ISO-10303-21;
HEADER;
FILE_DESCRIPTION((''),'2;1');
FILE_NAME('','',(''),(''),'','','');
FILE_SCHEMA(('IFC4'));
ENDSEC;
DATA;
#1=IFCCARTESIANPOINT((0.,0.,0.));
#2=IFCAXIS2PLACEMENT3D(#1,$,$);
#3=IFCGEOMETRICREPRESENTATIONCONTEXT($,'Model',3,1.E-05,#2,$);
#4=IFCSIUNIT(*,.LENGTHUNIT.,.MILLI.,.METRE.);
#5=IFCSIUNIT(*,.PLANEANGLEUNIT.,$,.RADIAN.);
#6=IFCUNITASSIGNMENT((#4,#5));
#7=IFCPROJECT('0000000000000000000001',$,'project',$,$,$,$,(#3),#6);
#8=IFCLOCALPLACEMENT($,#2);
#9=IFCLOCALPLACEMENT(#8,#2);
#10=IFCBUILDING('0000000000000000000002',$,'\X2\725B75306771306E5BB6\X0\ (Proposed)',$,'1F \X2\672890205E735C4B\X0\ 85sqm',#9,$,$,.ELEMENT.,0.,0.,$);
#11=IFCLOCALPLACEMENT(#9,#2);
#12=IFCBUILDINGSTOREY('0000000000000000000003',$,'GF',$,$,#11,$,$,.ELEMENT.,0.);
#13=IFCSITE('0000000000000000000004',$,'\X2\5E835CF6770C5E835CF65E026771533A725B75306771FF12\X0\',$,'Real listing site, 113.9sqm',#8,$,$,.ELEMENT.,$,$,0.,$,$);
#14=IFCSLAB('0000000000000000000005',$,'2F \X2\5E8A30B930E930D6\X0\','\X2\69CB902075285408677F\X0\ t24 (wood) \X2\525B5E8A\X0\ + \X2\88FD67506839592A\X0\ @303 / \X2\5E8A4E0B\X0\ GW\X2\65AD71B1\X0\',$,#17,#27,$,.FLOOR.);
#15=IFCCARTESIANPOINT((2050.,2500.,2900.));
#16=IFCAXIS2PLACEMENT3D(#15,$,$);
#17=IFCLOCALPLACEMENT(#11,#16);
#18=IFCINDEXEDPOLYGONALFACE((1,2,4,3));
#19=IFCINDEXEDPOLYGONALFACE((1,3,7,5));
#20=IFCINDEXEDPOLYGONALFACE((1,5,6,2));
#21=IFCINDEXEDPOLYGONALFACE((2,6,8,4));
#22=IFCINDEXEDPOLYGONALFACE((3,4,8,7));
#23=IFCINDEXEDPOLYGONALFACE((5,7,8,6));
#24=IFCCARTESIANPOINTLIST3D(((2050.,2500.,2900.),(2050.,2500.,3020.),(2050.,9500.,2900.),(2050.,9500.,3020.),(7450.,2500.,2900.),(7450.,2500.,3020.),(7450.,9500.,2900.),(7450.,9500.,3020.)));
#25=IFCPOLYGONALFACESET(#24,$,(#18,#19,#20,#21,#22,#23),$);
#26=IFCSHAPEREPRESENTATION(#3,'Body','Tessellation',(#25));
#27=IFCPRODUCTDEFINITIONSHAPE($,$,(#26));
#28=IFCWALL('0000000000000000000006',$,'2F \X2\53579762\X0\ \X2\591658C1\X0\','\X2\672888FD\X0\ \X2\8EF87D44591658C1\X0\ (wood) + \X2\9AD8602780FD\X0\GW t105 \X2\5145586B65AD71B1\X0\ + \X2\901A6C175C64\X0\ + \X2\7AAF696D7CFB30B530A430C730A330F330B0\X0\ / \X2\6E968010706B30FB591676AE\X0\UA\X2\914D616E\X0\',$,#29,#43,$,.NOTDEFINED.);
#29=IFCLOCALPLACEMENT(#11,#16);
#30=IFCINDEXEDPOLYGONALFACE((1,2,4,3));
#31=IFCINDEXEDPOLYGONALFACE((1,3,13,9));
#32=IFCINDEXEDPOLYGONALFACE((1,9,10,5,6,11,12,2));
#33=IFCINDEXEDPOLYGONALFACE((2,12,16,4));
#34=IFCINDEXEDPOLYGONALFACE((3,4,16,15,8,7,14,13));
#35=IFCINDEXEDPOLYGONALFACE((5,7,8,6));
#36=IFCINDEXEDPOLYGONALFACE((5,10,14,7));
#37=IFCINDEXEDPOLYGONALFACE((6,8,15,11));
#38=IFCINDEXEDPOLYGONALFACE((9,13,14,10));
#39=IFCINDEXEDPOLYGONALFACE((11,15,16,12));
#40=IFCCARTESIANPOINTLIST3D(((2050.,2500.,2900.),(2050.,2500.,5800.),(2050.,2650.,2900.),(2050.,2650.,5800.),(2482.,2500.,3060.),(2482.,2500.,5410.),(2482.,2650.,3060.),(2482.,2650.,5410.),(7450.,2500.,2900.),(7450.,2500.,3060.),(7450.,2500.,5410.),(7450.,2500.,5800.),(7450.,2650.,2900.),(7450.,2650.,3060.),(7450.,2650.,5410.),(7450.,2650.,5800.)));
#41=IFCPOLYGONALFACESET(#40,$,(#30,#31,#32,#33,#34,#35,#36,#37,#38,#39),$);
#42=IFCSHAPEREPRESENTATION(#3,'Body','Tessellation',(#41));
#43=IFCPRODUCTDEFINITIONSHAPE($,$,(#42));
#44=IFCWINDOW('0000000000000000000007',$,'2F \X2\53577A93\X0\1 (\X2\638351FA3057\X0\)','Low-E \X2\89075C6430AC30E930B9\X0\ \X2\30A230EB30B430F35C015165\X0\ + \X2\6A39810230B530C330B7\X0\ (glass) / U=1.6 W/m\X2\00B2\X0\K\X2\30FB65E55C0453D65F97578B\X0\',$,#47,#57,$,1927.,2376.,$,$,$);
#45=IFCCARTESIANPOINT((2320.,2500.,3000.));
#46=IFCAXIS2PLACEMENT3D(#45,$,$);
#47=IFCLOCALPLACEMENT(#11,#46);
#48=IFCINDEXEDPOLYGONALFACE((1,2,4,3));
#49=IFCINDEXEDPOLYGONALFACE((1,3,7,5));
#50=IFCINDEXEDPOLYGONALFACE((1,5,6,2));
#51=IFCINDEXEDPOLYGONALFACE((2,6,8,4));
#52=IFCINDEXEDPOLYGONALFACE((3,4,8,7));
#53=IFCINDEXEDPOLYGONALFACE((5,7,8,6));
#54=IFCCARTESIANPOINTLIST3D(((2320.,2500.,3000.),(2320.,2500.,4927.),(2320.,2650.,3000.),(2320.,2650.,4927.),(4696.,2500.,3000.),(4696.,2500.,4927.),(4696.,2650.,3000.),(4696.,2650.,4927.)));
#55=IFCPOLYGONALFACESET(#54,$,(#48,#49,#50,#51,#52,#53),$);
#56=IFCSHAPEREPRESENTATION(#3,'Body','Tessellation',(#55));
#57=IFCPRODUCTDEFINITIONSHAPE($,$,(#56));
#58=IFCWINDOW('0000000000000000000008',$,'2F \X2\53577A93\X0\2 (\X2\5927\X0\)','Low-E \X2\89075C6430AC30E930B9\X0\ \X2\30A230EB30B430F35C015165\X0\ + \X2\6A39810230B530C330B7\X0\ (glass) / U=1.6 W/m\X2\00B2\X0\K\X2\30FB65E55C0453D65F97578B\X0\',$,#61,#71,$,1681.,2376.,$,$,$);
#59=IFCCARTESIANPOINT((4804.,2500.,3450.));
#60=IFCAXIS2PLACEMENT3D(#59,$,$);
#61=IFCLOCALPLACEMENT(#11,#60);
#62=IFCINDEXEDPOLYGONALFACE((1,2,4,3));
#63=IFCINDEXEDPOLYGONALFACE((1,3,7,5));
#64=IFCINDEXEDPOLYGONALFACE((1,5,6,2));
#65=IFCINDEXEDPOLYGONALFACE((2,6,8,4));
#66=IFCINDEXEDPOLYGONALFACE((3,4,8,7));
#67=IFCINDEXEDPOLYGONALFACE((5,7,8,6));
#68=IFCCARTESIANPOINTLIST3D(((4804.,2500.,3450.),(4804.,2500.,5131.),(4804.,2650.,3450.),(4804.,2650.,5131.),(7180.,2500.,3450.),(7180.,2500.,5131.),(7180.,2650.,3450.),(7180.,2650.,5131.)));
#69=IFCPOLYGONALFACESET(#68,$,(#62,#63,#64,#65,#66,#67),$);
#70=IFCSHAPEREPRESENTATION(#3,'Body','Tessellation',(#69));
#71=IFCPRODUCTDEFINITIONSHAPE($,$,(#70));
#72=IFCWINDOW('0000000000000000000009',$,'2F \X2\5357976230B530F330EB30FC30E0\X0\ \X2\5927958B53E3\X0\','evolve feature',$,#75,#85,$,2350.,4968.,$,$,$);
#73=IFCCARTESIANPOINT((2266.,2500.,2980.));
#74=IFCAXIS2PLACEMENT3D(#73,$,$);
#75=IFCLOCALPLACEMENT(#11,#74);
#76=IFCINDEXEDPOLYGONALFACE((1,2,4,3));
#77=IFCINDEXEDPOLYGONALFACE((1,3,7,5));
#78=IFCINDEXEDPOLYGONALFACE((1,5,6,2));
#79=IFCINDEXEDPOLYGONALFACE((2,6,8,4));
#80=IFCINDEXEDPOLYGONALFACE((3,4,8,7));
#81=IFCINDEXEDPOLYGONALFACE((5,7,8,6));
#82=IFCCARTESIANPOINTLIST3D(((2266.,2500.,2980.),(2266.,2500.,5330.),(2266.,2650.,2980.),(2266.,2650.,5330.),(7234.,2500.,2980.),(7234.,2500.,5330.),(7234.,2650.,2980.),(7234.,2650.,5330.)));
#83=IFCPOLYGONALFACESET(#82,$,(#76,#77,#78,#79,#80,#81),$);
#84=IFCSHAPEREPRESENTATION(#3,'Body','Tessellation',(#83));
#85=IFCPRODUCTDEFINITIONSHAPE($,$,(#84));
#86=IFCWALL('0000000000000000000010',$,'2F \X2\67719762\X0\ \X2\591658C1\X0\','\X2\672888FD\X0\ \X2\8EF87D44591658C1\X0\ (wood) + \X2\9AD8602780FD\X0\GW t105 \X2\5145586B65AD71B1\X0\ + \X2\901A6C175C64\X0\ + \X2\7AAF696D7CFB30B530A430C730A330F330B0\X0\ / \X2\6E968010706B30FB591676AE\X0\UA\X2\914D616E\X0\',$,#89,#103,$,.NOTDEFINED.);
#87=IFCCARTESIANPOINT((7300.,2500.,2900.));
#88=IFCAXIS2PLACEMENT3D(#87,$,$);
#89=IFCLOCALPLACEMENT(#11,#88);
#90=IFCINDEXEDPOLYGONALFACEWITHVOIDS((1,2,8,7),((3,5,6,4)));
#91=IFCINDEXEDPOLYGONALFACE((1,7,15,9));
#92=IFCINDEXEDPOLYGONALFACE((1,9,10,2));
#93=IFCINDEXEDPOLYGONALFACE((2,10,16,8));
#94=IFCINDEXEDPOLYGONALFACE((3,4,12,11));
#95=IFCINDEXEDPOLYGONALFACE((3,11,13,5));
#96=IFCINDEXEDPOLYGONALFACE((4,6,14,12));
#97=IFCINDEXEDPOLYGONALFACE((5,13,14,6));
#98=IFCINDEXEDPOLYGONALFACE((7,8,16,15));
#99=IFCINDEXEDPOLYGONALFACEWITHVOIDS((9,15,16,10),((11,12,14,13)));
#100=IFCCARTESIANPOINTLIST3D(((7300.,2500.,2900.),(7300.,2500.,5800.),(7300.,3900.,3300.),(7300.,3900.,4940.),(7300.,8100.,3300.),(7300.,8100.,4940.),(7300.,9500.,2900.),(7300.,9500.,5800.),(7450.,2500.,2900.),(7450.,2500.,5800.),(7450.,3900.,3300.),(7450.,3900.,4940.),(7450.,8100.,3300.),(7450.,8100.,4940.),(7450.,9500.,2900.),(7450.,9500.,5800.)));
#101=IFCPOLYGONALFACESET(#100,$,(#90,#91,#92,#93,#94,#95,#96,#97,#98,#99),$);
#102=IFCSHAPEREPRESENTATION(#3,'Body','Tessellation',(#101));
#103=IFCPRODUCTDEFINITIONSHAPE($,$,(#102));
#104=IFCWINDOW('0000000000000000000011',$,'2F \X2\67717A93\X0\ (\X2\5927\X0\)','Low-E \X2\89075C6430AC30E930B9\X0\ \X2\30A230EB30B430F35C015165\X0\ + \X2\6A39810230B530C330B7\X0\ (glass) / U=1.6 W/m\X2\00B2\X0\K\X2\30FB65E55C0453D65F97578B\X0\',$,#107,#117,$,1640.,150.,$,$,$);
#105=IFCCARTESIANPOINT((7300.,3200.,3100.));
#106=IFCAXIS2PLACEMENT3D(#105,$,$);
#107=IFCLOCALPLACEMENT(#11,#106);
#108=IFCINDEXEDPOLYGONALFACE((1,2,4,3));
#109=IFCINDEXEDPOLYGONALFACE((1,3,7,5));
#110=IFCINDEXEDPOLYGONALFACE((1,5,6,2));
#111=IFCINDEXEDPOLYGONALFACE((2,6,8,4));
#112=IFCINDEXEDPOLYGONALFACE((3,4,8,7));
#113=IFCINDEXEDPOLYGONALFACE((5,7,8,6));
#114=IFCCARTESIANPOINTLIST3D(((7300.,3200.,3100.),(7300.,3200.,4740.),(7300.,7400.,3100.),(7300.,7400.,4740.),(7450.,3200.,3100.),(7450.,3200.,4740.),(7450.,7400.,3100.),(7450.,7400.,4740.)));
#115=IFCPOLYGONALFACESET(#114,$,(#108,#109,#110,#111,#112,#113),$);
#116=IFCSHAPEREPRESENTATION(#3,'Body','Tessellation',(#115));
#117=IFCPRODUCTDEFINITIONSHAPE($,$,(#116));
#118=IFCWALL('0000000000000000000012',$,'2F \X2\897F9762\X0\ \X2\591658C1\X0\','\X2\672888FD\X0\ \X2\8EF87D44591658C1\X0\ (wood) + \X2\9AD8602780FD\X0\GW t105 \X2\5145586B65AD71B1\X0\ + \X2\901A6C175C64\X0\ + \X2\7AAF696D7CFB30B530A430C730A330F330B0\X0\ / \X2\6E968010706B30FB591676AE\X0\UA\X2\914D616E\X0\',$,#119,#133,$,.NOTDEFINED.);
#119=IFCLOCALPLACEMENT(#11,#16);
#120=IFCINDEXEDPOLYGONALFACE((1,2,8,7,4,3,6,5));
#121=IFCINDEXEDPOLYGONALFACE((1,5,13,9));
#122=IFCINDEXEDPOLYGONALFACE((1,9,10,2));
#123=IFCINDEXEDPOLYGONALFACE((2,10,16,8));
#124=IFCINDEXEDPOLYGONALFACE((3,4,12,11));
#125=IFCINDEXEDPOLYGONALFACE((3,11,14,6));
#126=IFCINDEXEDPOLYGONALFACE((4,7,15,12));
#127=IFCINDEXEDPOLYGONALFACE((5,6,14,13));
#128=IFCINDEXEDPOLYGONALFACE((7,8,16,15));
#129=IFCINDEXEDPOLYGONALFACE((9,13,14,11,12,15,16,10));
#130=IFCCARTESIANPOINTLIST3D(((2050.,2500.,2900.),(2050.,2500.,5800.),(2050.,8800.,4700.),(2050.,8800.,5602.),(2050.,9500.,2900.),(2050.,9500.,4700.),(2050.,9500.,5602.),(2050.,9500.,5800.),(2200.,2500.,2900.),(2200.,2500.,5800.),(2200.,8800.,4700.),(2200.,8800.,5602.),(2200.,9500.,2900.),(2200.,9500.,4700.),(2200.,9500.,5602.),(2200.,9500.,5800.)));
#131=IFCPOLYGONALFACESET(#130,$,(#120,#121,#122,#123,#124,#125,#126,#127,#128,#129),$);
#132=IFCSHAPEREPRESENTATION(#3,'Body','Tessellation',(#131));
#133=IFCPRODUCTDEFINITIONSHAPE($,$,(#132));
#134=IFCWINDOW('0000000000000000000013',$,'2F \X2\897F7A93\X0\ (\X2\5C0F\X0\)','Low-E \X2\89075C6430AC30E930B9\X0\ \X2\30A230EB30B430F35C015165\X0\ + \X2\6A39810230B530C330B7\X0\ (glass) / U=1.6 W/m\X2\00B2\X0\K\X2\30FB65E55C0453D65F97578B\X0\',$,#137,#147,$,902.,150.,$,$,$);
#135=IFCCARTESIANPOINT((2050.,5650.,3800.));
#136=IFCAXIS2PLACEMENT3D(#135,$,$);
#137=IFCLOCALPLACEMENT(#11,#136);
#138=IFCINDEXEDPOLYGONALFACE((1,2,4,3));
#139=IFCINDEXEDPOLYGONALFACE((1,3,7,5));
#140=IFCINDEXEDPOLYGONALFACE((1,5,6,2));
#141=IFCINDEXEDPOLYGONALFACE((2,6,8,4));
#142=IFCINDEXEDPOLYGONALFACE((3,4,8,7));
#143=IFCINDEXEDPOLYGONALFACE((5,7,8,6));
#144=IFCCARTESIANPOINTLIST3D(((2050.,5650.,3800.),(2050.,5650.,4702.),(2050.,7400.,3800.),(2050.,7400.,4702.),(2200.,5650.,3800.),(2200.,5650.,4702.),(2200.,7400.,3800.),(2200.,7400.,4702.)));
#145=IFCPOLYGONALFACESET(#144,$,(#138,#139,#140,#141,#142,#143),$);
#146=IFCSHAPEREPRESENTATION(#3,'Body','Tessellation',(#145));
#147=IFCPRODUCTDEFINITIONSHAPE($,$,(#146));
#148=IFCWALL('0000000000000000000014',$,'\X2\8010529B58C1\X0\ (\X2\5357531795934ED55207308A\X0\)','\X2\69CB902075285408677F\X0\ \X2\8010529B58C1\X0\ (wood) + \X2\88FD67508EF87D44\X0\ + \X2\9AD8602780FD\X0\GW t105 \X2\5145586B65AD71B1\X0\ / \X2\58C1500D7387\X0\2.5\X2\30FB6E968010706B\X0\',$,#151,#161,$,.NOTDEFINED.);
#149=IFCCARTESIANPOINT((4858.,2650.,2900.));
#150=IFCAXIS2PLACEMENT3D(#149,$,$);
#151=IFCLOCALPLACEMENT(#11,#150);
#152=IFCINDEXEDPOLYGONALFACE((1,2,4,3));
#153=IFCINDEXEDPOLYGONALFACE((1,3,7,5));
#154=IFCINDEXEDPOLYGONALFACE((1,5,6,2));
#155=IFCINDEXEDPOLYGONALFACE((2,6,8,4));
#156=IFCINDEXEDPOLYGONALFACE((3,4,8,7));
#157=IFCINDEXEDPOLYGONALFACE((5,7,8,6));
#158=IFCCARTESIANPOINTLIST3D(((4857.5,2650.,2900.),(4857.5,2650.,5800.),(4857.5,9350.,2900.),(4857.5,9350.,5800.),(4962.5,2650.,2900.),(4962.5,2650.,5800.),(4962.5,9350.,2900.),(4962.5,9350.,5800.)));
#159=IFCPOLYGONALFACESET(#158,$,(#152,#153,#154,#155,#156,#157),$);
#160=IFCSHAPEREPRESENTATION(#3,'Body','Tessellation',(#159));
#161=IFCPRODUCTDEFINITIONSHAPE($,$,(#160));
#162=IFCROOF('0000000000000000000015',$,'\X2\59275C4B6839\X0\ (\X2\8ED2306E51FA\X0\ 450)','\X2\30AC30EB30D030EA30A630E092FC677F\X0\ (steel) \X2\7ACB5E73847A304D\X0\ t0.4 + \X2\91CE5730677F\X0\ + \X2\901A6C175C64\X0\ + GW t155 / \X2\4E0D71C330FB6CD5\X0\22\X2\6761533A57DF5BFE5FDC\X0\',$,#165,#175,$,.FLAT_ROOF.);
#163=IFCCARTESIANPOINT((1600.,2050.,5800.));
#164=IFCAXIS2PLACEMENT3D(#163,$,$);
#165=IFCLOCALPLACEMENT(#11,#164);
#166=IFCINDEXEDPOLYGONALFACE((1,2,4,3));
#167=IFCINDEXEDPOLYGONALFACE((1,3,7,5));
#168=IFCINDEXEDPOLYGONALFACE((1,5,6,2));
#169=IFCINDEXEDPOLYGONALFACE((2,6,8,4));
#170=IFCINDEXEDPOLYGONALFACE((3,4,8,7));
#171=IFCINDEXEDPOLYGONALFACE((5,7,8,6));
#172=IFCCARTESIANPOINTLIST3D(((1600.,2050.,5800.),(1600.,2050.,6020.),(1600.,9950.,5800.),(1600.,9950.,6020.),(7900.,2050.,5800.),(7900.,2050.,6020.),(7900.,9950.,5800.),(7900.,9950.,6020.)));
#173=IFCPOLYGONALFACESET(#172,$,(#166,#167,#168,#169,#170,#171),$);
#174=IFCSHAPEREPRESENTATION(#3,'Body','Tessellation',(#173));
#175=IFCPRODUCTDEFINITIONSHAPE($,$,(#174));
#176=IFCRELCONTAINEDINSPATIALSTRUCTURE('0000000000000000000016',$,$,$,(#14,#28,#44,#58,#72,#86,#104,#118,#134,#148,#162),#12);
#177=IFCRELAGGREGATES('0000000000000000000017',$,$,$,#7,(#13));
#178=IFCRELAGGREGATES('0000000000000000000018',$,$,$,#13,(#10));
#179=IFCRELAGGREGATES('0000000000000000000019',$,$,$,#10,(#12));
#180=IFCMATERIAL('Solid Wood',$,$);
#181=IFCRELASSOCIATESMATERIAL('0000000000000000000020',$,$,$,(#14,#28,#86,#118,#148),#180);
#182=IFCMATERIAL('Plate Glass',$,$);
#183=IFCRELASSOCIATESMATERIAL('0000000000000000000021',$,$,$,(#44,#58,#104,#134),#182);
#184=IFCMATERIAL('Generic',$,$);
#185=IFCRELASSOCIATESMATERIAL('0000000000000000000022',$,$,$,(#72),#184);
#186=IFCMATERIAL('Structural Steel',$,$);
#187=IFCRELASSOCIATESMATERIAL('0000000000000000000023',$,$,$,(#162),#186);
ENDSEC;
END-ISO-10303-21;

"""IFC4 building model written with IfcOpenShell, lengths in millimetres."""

from ifc_helpers import new_model, si_unit, frame, frame_2d, origin, place, context, project, spatial, rectangle, extrude, material, element, fill, save


model = new_model("IFC4")

# Units and contexts
model_context = context("Model", 3, precision=1e-05, world=origin())
ifc_project = project(units=[si_unit("LENGTHUNIT", "METRE", prefix="MILLI"), si_unit("PLANEANGLEUNIT", "RADIAN")], contexts=[model_context])

# Site, building, storey
site_placement = place(None, origin())
site = spatial("IfcSite", under=ifc_project, at=site_placement, Name="広島県広島市東区牛田東２", ObjectType="Real listing site, 113.9sqm", CompositionType="ELEMENT", RefElevation=0.0)
building_placement = place(site_placement, origin())
building = spatial("IfcBuilding", under=site, at=building_placement, Name="牛田東の家 (Proposed)", ObjectType="1F 木造平屋 85sqm", CompositionType="ELEMENT", ElevationOfRefHeight=0.0, ElevationOfTerrain=0.0)
storey_placement = place(building_placement, origin())
storey = spatial("IfcBuildingStorey", under=building, at=storey_placement, Name="GF", CompositionType="ELEMENT", Elevation=0.0)

# Slab
ifc_material_1 = material(Name="Solid Wood")
slab_placement = place(storey_placement, frame((2050.0, 2500.0, 2900.0)))
element("IfcSlab", 1, at=slab_placement, inside=storey, material=ifc_material_1, Name="2F 床スラブ", Description="構造用合板 t24 (wood) 剛床 + 製材根太 @303 / 床下 GW断熱", PredefinedType="FLOOR", context=model_context, shape_type="SweptSolid", body=[
    extrude(rectangle(XDim=5400.0, YDim=7000.0, at=frame_2d((2700.0, 3500.0))), frame((2050.0, 2500.0, 2900.0)), (0.0, 0.0, 1.0), 120.0),
])

# Wall, openings, windows
wall_1_placement = place(storey_placement, frame((2050.0, 2500.0, 2900.0)))
wall_1 = element("IfcWall", 2, at=wall_1_placement, inside=storey, material=ifc_material_1, Name="2F 南面 外壁", Description="木製 軸組外壁 (wood) + 高性能GW t105 充填断熱 + 通気層 + 窯業系サイディング / 準耐火・外皮UA配慮", PredefinedType="NOTDEFINED", context=model_context, shape_type="SweptSolid", body=[
    extrude(rectangle(XDim=5400.0, YDim=150.0, at=frame_2d((2700.0, 75.0))), frame((2050.0, 2500.0, 2900.0)), (0.0, 0.0, 1.0), 2900.0),
])
opening_1_placement = place(storey_placement, frame((2320.0, 2500.0, 3000.0)))
opening_1 = element("IfcOpeningElement", 3, at=opening_1_placement, cuts=wall_1, PredefinedType="NOTDEFINED", context=model_context, shape_type="SweptSolid", body=[
    extrude(rectangle(XDim=2376.0, YDim=150.0, at=frame_2d((1188.0, 75.0))), frame((2320.0, 2500.0, 3000.0)), (0.0, 0.0, 1.0), 1927.0),
])
opening_2_placement = place(storey_placement, frame((4804.0, 2500.0, 3450.0)))
opening_2 = element("IfcOpeningElement", 4, at=opening_2_placement, cuts=wall_1, PredefinedType="NOTDEFINED", context=model_context, shape_type="SweptSolid", body=[
    extrude(rectangle(XDim=2376.0, YDim=150.0, at=frame_2d((1188.0, 75.0))), frame((4804.0, 2500.0, 3450.0)), (0.0, 0.0, 1.0), 1681.0),
])
opening_3_placement = place(storey_placement, frame((2266.0, 2500.0, 2980.0)))
opening_3 = element("IfcOpeningElement", 5, at=opening_3_placement, cuts=wall_1, PredefinedType="NOTDEFINED", context=model_context, shape_type="SweptSolid", body=[
    extrude(rectangle(XDim=4968.0, YDim=150.0, at=frame_2d((2484.0, 75.0))), frame((2266.0, 2500.0, 2980.0)), (0.0, 0.0, 1.0), 2350.0),
])
ifc_material_2 = material(Name="Plate Glass")
window_1_placement = place(storey_placement, frame((2320.0, 2500.0, 3000.0)))
window_1 = element("IfcWindow", 6, at=window_1_placement, inside=storey, material=ifc_material_2, Name="2F 南窓1 (掃出し)", Description="Low-E 複層ガラス アルゴン封入 + 樹脂サッシ (glass) / U=1.6 W/m²K・日射取得型", OverallHeight=1927.0, OverallWidth=2376.0, context=model_context, shape_type="SweptSolid", body=[
    extrude(rectangle(XDim=2376.0, YDim=150.0, at=frame_2d((1188.0, 75.0))), frame((2320.0, 2500.0, 3000.0)), (0.0, 0.0, 1.0), 1927.0),
])
fill(opening_1, window_1)
window_2_placement = place(storey_placement, frame((4804.0, 2500.0, 3450.0)))
window_2 = element("IfcWindow", 7, at=window_2_placement, inside=storey, material=ifc_material_2, Name="2F 南窓2 (大)", Description="Low-E 複層ガラス アルゴン封入 + 樹脂サッシ (glass) / U=1.6 W/m²K・日射取得型", OverallHeight=1681.0, OverallWidth=2376.0, context=model_context, shape_type="SweptSolid", body=[
    extrude(rectangle(XDim=2376.0, YDim=150.0, at=frame_2d((1188.0, 75.0))), frame((4804.0, 2500.0, 3450.0)), (0.0, 0.0, 1.0), 1681.0),
])
fill(opening_2, window_2)
ifc_material_3 = material(Name="Generic")
window_3_placement = place(storey_placement, frame((2266.0, 2500.0, 2980.0)))
window_3 = element("IfcWindow", 8, at=window_3_placement, inside=storey, material=ifc_material_3, Name="2F 南面サンルーム 大開口", Description="evolve feature", OverallHeight=2350.0, OverallWidth=4968.0, context=model_context, shape_type="SweptSolid", body=[
    extrude(rectangle(XDim=4968.0, YDim=150.0, at=frame_2d((2484.0, 75.0))), frame((2266.0, 2500.0, 2980.0)), (0.0, 0.0, 1.0), 2350.0),
])
fill(opening_3, window_3)

# Walls, openings, windows
wall_2_placement = place(storey_placement, frame((7300.0, 2500.0, 2900.0)))
wall_2 = element("IfcWall", 9, at=wall_2_placement, inside=storey, material=ifc_material_1, Name="2F 東面 外壁", Description="木製 軸組外壁 (wood) + 高性能GW t105 充填断熱 + 通気層 + 窯業系サイディング / 準耐火・外皮UA配慮", PredefinedType="NOTDEFINED", context=model_context, shape_type="SweptSolid", body=[
    extrude(rectangle(XDim=150.0, YDim=7000.0, at=frame_2d((75.0, 3500.0))), frame((7300.0, 2500.0, 2900.0)), (0.0, 0.0, 1.0), 2900.0),
])
opening_4_placement = place(storey_placement, frame((7300.0, 3200.0, 3100.0)))
opening_4 = element("IfcOpeningElement", 10, at=opening_4_placement, cuts=wall_2, PredefinedType="NOTDEFINED", context=model_context, shape_type="SweptSolid", body=[
    extrude(rectangle(XDim=150.0, YDim=4200.0, at=frame_2d((75.0, 2100.0))), frame((7300.0, 3200.0, 3100.0)), (0.0, 0.0, 1.0), 1640.0),
])
window_4_placement = place(storey_placement, frame((7300.0, 3200.0, 3100.0)))
window_4 = element("IfcWindow", 11, at=window_4_placement, inside=storey, material=ifc_material_2, Name="2F 東窓 (大)", Description="Low-E 複層ガラス アルゴン封入 + 樹脂サッシ (glass) / U=1.6 W/m²K・日射取得型", OverallHeight=1640.0, OverallWidth=150.0, context=model_context, shape_type="SweptSolid", body=[
    extrude(rectangle(XDim=150.0, YDim=4200.0, at=frame_2d((75.0, 2100.0))), frame((7300.0, 3200.0, 3100.0)), (0.0, 0.0, 1.0), 1640.0),
])
fill(opening_4, window_4)
wall_3_placement = place(storey_placement, frame((2050.0, 2500.0, 2900.0)))
wall_3 = element("IfcWall", 12, at=wall_3_placement, inside=storey, material=ifc_material_1, Name="2F 西面 外壁", Description="木製 軸組外壁 (wood) + 高性能GW t105 充填断熱 + 通気層 + 窯業系サイディング / 準耐火・外皮UA配慮", PredefinedType="NOTDEFINED", context=model_context, shape_type="SweptSolid", body=[
    extrude(rectangle(XDim=150.0, YDim=7000.0, at=frame_2d((75.0, 3500.0))), frame((2050.0, 2500.0, 2900.0)), (0.0, 0.0, 1.0), 2900.0),
])
opening_5_placement = place(storey_placement, frame((2050.0, 5650.0, 3800.0)))
opening_5 = element("IfcOpeningElement", 13, at=opening_5_placement, cuts=wall_3, PredefinedType="NOTDEFINED", context=model_context, shape_type="SweptSolid", body=[
    extrude(rectangle(XDim=150.0, YDim=1750.0, at=frame_2d((75.0, 875.0))), frame((2050.0, 5650.0, 3800.0)), (0.0, 0.0, 1.0), 902.0),
])
window_5_placement = place(storey_placement, frame((2050.0, 5650.0, 3800.0)))
window_5 = element("IfcWindow", 14, at=window_5_placement, inside=storey, material=ifc_material_2, Name="2F 西窓 (小)", Description="Low-E 複層ガラス アルゴン封入 + 樹脂サッシ (glass) / U=1.6 W/m²K・日射取得型", OverallHeight=902.0, OverallWidth=150.0, context=model_context, shape_type="SweptSolid", body=[
    extrude(rectangle(XDim=150.0, YDim=1750.0, at=frame_2d((75.0, 875.0))), frame((2050.0, 5650.0, 3800.0)), (0.0, 0.0, 1.0), 902.0),
])
fill(opening_5, window_5)

# Wall
wall_4_placement = place(storey_placement, frame((4858.0, 2650.0, 2900.0)))
element("IfcWall", 15, at=wall_4_placement, inside=storey, material=ifc_material_1, Name="耐力壁 (南北間仕切り)", Description="構造用合板 耐力壁 (wood) + 製材軸組 + 高性能GW t105 充填断熱 / 壁倍率2.5・準耐火", PredefinedType="NOTDEFINED", context=model_context, shape_type="SweptSolid", body=[
    extrude(rectangle(XDim=105.0, YDim=6700.0, at=frame_2d((52.0, 3350.0))), frame((4858.0, 2650.0, 2900.0)), (0.0, 0.0, 1.0), 2900.0),
])

# Roof
ifc_material_4 = material(Name="Structural Steel")
roof_1_placement = place(storey_placement, frame((1600.0, 2050.0, 5800.0)))
element("IfcRoof", 16, at=roof_1_placement, inside=storey, material=ifc_material_4, Name="大屋根 (軒の出 450)", Description="ガルバリウム鋼板 (steel) 立平葺き t0.4 + 野地板 + 通気層 + GW t155 / 不燃・法22条区域対応", PredefinedType="FLAT_ROOF", context=model_context, shape_type="SweptSolid", body=[
    extrude(rectangle(XDim=6300.0, YDim=7900.0, at=frame_2d((3150.0, 3950.0))), frame((1600.0, 2050.0, 5800.0)), (0.0, 0.0, 1.0), 220.0),
])

save(model, "model.ifc")
